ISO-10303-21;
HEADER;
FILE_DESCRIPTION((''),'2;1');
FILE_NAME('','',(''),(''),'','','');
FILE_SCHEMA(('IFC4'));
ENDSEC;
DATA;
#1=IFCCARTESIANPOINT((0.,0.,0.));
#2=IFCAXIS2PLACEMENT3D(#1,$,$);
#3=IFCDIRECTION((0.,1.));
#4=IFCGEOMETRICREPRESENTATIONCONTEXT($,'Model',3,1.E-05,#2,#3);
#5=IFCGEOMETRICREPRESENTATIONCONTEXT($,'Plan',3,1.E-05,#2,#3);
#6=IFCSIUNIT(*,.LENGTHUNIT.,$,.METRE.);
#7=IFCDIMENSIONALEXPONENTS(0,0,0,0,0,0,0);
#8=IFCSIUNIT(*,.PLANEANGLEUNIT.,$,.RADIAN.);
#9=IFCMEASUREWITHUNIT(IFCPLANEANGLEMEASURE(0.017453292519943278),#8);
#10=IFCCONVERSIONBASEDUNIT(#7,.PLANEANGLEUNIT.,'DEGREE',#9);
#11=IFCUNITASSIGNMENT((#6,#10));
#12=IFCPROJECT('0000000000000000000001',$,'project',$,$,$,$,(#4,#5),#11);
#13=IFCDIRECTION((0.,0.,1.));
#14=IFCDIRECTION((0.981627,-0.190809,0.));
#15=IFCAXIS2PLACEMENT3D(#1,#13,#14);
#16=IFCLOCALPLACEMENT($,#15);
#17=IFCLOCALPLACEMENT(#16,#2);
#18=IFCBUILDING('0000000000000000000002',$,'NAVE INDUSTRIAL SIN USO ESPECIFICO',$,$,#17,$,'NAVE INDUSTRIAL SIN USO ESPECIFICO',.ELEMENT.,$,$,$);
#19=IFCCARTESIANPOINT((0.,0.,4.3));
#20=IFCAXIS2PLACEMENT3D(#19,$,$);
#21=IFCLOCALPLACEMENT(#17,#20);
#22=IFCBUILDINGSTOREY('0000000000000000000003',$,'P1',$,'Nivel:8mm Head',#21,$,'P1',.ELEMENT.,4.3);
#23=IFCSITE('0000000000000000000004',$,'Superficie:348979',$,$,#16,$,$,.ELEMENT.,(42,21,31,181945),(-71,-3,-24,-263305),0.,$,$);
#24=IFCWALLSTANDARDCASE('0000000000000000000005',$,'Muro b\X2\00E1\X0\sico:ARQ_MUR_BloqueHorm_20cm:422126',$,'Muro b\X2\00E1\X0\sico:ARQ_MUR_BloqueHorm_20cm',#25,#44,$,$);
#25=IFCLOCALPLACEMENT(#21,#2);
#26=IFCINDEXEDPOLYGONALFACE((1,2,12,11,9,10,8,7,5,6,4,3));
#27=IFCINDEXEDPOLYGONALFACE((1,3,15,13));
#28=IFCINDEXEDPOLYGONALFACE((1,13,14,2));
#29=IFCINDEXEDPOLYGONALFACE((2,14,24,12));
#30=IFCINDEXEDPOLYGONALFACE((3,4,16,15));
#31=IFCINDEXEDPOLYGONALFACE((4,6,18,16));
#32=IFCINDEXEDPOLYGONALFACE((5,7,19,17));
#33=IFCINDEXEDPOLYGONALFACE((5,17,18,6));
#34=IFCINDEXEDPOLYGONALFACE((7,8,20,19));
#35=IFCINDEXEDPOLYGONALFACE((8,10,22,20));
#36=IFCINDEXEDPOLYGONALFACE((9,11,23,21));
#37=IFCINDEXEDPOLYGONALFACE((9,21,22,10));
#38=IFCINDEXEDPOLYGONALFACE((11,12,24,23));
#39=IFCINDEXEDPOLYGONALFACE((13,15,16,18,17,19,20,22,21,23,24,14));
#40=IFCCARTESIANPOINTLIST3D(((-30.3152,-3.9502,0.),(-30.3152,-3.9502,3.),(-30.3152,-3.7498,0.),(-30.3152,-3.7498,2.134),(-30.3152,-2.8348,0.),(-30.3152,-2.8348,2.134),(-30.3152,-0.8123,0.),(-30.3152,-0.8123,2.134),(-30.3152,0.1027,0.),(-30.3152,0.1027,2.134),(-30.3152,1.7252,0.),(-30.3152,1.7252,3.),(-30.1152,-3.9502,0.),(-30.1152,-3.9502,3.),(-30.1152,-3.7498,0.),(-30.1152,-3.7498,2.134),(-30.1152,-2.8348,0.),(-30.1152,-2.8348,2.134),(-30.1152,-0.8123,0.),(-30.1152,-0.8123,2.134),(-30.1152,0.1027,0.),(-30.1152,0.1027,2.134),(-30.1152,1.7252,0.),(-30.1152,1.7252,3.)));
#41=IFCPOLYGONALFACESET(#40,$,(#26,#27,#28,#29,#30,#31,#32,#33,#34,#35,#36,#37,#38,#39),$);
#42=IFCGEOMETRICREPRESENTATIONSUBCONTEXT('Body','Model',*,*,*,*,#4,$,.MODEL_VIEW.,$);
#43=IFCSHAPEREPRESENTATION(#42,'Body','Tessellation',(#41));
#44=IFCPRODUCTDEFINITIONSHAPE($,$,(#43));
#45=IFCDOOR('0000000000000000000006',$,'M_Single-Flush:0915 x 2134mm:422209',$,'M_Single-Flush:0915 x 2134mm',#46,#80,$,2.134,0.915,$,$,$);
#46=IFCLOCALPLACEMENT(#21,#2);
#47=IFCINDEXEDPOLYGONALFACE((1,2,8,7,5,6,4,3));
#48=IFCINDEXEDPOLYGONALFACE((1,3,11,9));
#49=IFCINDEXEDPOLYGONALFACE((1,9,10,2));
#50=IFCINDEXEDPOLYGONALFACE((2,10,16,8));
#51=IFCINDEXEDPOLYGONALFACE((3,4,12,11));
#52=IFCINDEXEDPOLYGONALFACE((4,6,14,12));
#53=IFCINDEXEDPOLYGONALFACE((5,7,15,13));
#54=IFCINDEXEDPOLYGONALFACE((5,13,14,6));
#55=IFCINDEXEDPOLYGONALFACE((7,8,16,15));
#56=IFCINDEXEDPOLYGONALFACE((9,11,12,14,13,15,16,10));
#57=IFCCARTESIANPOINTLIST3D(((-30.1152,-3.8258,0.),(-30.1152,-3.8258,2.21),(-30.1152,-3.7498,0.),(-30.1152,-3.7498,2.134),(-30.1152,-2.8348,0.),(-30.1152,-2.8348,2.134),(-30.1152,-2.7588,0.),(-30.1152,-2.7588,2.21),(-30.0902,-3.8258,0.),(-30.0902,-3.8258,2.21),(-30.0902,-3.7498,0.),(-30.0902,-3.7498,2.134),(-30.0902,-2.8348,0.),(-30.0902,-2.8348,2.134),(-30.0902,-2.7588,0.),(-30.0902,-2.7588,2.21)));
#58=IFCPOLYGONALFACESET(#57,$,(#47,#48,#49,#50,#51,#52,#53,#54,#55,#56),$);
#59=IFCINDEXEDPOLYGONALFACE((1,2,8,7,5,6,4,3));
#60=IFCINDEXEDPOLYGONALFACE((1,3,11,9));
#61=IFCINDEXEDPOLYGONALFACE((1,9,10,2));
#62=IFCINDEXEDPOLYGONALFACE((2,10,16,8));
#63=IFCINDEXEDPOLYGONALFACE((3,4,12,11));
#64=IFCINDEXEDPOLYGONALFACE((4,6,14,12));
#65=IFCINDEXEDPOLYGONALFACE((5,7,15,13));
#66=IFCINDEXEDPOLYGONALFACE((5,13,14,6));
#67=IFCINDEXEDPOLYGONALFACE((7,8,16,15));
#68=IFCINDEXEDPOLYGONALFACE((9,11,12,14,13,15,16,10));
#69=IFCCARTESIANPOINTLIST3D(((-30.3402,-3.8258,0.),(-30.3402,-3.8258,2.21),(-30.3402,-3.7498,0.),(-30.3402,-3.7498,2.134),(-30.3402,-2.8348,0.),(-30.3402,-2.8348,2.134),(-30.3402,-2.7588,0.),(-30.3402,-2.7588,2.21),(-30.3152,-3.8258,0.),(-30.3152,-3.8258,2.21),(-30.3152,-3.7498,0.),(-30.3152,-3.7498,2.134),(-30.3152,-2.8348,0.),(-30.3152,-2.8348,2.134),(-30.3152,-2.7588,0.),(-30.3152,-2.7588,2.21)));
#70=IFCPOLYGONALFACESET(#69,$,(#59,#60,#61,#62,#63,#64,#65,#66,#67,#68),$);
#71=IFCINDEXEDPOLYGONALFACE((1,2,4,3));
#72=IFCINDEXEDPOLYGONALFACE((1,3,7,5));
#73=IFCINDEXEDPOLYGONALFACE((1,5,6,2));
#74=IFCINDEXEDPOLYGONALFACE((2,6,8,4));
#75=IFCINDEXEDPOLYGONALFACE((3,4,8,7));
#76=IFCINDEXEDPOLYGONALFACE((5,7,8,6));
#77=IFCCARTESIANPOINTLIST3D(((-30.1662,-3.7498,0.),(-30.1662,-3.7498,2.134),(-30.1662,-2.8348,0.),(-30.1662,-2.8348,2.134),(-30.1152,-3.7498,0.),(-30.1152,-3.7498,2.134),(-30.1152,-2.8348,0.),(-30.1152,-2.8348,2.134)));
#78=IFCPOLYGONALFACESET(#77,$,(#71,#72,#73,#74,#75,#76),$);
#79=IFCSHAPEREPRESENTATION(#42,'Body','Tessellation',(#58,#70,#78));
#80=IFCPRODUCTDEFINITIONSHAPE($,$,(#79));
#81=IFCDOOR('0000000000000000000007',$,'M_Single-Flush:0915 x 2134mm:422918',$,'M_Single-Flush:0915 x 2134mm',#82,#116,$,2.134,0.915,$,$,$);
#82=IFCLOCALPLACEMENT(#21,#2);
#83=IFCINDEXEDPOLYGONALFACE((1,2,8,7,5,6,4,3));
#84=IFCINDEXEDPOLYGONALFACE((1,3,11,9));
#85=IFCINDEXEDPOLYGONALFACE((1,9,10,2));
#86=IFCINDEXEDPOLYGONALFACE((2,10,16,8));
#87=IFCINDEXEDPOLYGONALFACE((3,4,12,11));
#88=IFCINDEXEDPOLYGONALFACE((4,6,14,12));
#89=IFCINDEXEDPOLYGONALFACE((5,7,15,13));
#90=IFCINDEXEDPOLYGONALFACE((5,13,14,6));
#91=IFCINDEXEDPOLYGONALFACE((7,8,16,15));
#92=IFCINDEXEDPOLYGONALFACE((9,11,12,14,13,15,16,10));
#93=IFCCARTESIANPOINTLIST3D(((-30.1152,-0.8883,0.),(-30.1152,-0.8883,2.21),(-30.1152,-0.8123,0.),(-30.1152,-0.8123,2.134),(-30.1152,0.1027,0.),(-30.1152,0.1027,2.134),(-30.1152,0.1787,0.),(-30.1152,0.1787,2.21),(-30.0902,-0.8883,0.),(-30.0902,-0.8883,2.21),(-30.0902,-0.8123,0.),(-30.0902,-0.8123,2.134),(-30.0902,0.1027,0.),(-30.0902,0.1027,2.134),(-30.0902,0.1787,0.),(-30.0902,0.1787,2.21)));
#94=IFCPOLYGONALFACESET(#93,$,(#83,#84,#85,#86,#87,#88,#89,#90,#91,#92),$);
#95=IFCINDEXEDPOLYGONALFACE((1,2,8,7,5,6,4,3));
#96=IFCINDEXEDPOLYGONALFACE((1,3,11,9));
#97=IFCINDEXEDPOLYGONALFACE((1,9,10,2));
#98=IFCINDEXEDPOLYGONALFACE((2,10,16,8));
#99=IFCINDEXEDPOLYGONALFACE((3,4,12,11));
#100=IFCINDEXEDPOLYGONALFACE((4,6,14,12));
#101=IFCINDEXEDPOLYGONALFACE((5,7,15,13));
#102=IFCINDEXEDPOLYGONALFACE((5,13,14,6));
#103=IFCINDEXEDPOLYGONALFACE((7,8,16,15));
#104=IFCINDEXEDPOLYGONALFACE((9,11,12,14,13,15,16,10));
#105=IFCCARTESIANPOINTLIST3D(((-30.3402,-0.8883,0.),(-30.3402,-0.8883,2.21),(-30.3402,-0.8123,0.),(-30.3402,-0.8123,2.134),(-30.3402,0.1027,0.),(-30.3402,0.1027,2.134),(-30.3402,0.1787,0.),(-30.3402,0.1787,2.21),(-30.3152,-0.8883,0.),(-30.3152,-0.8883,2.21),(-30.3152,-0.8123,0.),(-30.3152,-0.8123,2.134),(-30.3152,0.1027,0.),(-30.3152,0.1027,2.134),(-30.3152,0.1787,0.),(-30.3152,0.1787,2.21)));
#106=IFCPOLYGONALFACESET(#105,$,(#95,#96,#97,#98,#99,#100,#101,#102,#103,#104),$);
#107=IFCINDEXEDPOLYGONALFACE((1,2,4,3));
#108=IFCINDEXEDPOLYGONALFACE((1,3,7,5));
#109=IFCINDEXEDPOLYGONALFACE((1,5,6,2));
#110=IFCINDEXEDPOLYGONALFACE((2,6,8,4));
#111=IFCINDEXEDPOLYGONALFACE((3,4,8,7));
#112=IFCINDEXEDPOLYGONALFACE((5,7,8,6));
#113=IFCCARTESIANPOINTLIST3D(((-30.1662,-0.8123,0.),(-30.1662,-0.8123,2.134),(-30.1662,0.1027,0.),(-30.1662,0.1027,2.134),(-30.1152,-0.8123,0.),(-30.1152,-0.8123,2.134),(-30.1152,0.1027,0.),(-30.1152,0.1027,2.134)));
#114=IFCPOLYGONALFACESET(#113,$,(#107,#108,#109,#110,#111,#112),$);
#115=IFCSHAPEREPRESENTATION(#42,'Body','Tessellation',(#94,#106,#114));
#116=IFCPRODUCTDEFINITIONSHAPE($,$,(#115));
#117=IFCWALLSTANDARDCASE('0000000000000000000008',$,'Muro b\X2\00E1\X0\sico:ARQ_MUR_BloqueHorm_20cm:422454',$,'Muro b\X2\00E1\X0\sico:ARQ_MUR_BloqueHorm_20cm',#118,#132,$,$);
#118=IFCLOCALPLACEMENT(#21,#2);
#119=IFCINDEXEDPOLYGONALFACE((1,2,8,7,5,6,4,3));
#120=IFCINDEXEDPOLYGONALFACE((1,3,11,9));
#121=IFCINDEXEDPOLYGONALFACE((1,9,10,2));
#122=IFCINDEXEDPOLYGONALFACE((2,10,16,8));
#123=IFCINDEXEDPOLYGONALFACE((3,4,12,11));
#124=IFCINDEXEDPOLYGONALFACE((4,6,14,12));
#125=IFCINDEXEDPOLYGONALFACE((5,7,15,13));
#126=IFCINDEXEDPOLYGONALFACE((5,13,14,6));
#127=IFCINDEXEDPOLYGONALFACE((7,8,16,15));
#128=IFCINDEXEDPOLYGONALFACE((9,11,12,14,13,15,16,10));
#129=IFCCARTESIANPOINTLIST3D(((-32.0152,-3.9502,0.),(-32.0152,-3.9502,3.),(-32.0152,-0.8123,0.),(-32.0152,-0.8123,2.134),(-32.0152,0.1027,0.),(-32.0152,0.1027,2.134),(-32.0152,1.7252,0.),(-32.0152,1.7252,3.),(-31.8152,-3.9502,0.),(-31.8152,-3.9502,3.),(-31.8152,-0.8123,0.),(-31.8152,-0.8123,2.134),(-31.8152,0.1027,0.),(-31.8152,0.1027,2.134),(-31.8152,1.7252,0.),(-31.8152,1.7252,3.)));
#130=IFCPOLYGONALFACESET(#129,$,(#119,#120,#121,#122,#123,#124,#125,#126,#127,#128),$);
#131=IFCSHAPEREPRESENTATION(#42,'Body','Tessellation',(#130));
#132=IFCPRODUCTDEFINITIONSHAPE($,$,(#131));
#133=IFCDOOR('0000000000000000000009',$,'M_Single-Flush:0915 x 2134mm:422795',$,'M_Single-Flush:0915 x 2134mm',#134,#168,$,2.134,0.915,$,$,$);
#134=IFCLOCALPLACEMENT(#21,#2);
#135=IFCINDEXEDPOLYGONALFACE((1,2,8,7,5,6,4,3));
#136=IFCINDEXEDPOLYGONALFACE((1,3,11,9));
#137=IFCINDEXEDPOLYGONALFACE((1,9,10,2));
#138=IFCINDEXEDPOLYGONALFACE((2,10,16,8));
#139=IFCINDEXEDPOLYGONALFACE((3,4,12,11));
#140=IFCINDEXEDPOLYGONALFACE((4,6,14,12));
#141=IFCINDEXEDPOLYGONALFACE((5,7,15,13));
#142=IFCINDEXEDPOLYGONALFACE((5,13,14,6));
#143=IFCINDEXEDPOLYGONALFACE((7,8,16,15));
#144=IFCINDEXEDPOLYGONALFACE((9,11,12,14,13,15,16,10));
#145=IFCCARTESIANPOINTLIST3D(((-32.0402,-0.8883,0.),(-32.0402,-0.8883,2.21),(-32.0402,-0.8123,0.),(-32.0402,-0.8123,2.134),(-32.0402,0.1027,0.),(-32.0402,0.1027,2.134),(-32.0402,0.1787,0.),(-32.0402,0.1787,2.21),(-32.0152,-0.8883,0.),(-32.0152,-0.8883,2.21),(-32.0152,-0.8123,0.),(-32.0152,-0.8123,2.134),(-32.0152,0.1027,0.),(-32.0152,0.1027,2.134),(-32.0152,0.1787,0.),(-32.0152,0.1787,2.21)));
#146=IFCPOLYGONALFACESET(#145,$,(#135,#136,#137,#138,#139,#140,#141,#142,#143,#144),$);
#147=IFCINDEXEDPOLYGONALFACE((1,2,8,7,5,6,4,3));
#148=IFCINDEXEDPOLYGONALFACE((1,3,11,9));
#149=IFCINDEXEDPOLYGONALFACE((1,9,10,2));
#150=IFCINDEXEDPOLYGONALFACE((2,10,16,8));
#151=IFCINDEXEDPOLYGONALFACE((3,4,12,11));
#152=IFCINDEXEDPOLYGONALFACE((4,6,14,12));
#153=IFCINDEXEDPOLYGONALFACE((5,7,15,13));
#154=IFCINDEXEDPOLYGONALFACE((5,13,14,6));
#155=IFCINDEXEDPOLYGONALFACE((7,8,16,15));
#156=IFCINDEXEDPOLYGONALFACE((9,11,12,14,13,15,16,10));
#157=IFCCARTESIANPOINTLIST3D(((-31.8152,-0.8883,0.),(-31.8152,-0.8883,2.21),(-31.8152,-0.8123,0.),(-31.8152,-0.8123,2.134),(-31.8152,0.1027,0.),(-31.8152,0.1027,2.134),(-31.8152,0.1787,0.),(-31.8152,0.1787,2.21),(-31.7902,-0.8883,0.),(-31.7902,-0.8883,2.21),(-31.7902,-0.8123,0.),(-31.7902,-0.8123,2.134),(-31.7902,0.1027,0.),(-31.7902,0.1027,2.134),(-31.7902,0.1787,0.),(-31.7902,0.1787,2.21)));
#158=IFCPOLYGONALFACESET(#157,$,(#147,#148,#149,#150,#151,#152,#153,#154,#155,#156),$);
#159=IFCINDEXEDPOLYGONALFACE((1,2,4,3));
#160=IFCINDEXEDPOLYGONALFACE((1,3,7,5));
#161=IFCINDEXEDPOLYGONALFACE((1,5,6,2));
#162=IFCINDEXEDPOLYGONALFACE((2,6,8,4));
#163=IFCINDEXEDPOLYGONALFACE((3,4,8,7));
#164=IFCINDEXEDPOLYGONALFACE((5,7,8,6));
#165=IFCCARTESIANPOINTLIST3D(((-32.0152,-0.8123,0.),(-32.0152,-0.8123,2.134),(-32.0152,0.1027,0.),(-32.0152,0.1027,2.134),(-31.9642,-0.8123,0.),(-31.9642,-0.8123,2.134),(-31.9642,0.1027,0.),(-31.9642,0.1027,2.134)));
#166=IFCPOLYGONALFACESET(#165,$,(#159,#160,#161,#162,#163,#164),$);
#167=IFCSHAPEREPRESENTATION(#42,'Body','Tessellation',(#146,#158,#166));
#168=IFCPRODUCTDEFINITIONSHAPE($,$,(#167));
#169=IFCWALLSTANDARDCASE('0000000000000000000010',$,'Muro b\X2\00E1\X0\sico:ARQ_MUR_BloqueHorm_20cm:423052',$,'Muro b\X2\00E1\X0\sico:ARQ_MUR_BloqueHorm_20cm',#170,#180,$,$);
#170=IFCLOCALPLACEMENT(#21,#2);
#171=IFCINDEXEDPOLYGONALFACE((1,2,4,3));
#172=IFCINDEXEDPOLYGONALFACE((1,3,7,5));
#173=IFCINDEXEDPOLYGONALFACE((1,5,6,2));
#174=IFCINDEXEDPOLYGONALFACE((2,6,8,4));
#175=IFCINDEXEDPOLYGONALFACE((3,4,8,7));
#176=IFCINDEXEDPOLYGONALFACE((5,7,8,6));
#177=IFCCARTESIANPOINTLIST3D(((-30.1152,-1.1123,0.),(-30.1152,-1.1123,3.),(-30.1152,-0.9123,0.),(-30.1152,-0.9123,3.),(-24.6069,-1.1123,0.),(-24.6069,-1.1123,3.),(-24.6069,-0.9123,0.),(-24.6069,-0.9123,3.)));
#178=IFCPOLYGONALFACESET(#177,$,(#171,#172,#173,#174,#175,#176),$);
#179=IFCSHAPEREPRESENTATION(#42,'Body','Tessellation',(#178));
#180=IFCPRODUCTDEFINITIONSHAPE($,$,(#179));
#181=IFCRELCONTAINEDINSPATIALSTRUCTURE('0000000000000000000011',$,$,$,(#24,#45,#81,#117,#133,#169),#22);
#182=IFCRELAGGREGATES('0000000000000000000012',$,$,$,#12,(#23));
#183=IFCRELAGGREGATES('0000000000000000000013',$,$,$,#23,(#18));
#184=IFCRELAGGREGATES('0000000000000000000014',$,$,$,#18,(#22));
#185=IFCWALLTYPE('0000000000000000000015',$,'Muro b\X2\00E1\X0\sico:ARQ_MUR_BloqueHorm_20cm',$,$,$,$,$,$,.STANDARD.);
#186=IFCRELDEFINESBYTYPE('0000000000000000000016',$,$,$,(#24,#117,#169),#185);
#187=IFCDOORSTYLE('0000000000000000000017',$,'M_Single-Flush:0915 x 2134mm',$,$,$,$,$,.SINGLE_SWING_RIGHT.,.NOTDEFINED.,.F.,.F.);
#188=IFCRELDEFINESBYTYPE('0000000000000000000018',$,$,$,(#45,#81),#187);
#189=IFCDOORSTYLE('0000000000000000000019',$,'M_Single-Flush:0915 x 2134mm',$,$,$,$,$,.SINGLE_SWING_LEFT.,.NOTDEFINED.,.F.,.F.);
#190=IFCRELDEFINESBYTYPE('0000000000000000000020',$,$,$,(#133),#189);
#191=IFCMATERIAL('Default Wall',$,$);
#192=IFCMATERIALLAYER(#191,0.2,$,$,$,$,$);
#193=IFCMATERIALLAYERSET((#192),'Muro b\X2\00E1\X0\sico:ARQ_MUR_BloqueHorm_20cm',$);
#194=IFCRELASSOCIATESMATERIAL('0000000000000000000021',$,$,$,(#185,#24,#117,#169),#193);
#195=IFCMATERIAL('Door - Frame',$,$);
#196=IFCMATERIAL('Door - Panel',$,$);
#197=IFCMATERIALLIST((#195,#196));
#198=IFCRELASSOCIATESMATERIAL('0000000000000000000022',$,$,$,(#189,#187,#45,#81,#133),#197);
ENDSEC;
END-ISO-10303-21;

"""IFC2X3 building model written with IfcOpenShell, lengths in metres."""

from ifc_helpers import new_model, entity, si_unit, converted_unit, direction, frame, frame_2d, origin, place, context, subcontext, project, spatial, polyline, rectangle, outline, extrude, source, transform, mapped, material, material_list, layer, layer_set, layer_usage, type_object, type_shapes, element, fill, save


model = new_model("IFC2X3")

# Units and contexts
model_context = context("Model", 3, precision=1e-05, world=origin(), true_north=direction((0.0, 1.0)))
plan_context = context("Plan", 3, precision=1e-05, world=origin(), true_north=direction((0.0, 1.0)))
body_context = subcontext(model_context, "Body", "Model", "MODEL_VIEW")
ifc_project = project(units=[si_unit("LENGTHUNIT", "METRE"), converted_unit("PLANEANGLEUNIT", "DEGREE", entity("IfcPlaneAngleMeasure", 0.017453292519943278), si_unit("PLANEANGLEUNIT", "RADIAN"), dimensions=[0, 0, 0, 0, 0, 0, 0])], contexts=[model_context, plan_context])

# Site, building, storey
site_placement = place(None, frame((0.0, 0.0, 0.0), z_axis=(0.0, 0.0, 1.0), x_axis=(0.981627, -0.190809, 0.0)))
site = spatial("IfcSite", under=ifc_project, at=site_placement, Name="Superficie:348979", CompositionType="ELEMENT", RefLatitude=(42, 21, 31, 181945), RefLongitude=(-71, -3, -24, -263305), RefElevation=0.0)
building_placement = place(site_placement, origin())
building = spatial("IfcBuilding", under=site, at=building_placement, Name="NAVE INDUSTRIAL SIN USO ESPECIFICO", LongName="NAVE INDUSTRIAL SIN USO ESPECIFICO", CompositionType="ELEMENT")
storey_placement = place(building_placement, frame((0.0, 0.0, 4.3)))
storey = spatial("IfcBuildingStorey", under=building, at=storey_placement, Name="P1", ObjectType="Nivel:8mm Head", LongName="P1", CompositionType="ELEMENT", Elevation=4.3)

# Shared definitions
ifc_material_1 = material(Name="Default Wall")
ifc_layer_1 = layer(ifc_material_1, 0.2)
ifc_layer_set_1 = layer_set([ifc_layer_1], Name="Muro básico:ARQ_MUR_BloqueHorm_20cm")
wall_type_1 = type_object("IfcWallType", Name="Muro básico:ARQ_MUR_BloqueHorm_20cm", PredefinedType="STANDARD", material=ifc_layer_set_1)

# Shared definitions
ifc_material_2 = material(Name="Door - Frame")
ifc_material_3 = material(Name="Door - Panel")
ifc_material_list = material_list([ifc_material_2, ifc_material_3])
door_style_1 = type_object("IfcDoorStyle", Name="M_Single-Flush:0915 x 2134mm", ConstructionType="NOTDEFINED", OperationType="SINGLE_SWING_LEFT", ParameterTakesPrecedence=False, Sizeable=False, material=ifc_material_list)
shared_shape_1 = source(origin(), body_context, "Body", "SweptSolid", [
    extrude(outline(polyline([(-0.5335, -1.124), (0.5335, -1.124), (0.5335, 1.086), (0.4575, 1.086), (0.4575, -1.048), (-0.4575, -1.048), (-0.4575, 1.086), (-0.5335, 1.086), (-0.5335, -1.124)])), frame((0.4575, 0.225, 1.086), z_axis=(0.0, -1.0, 0.0), x_axis=(-1.0, 0.0, 0.0)), (0.0, 0.0, 1.0), 0.025),
    extrude(outline(polyline([(-1.124, -0.5335), (1.086, -0.5335), (1.086, -0.4575), (-1.048, -0.4575), (-1.048, 0.4575), (1.086, 0.4575), (1.086, 0.5335), (-1.124, 0.5335), (-1.124, -0.5335)])), frame((0.4575, 0.0, 1.086), z_axis=(0.0, -1.0, 0.0), x_axis=(0.0, 0.0, -1.0)), (0.0, 0.0, 1.0), 0.025),
    extrude(rectangle(XDim=0.915, YDim=0.051, at=frame_2d((0.0, 0.0), x_axis=(1.0, 0.0))), frame((0.4575, 0.1745, 0.0)), (0.0, 0.0, 1.0), 2.134),
])
type_shapes(door_style_1, [shared_shape_1])

# Wall, openings, doors
ifc_layer_usage_1 = layer_usage(ifc_layer_set_1, "AXIS2", "NEGATIVE", 0.1)
wall_1_placement = place(storey_placement, frame((-30.2152, -3.9502, 0.0), z_axis=(0.0, 0.0, 1.0), x_axis=(0.0, 1.0, 0.0)))
wall_1 = element("IfcWallStandardCase", 1, at=wall_1_placement, inside=storey, type_object=wall_type_1, material=ifc_layer_usage_1, Name="Muro básico:ARQ_MUR_BloqueHorm_20cm:422126", ObjectType="Muro básico:ARQ_MUR_BloqueHorm_20cm", context=body_context, shape_type="SweptSolid", body=[
    extrude(rectangle(XDim=5.6754, YDim=0.2, at=frame_2d((2.8377, 0.0), x_axis=(1.0, 0.0))), origin(), (0.0, 0.0, 1.0), 3.0),
])
opening_1_placement = place(wall_1_placement, frame((1.1154, 0.1, 0.0)))
opening_1 = element("IfcOpeningElement", 2, at=opening_1_placement, cuts=wall_1, ObjectType="Opening", context=body_context, shape_type="SweptSolid", body=[
    extrude(rectangle(XDim=0.915, YDim=2.134, at=frame_2d((1.067, 0.4575), x_axis=(0.0, 1.0))), frame((0.0, 0.0, 0.0), z_axis=(0.0, -1.0, 0.0), x_axis=(0.0, 0.0, 1.0)), (0.0, 0.0, 1.0), 0.2),
])
opening_2_placement = place(wall_1_placement, frame((4.0529, 0.1, 0.0)))
opening_2 = element("IfcOpeningElement", 3, at=opening_2_placement, cuts=wall_1, ObjectType="Opening", context=body_context, shape_type="SweptSolid", body=[
    extrude(rectangle(XDim=0.915, YDim=2.134, at=frame_2d((1.067, 0.4575), x_axis=(0.0, 1.0))), frame((0.0, 0.0, 0.0), z_axis=(0.0, -1.0, 0.0), x_axis=(0.0, 0.0, 1.0)), (0.0, 0.0, 1.0), 0.2),
])
door_style_2 = type_object("IfcDoorStyle", Name="M_Single-Flush:0915 x 2134mm", ConstructionType="NOTDEFINED", OperationType="SINGLE_SWING_RIGHT", ParameterTakesPrecedence=False, Sizeable=False, material=ifc_material_list)
shared_shape_2 = source(origin(), body_context, "Body", "SweptSolid", [
    extrude(outline(polyline([(-0.5335, -1.124), (0.5335, -1.124), (0.5335, 1.086), (0.4575, 1.086), (0.4575, -1.048), (-0.4575, -1.048), (-0.4575, 1.086), (-0.5335, 1.086), (-0.5335, -1.124)])), frame((0.4575, 0.2, 1.086), z_axis=(0.0, 1.0, 0.0), x_axis=(1.0, 0.0, 0.0)), (0.0, 0.0, 1.0), 0.025),
    extrude(outline(polyline([(-1.124, -0.5335), (1.086, -0.5335), (1.086, -0.4575), (-1.048, -0.4575), (-1.048, 0.4575), (1.086, 0.4575), (1.086, 0.5335), (-1.124, 0.5335), (-1.124, -0.5335)])), frame((0.4575, -0.025, 1.086), z_axis=(0.0, 1.0, 0.0), x_axis=(0.0, 0.0, -1.0)), (0.0, 0.0, 1.0), 0.025),
    extrude(rectangle(XDim=0.051, YDim=0.915, at=frame_2d((0.0, 0.0), x_axis=(1.0, 0.0))), frame((0.4575, 0.1745, 0.0), z_axis=(0.0, 0.0, 1.0), x_axis=(0.0, 1.0, 0.0)), (0.0, 0.0, 1.0), 2.134),
])
type_shapes(door_style_2, [shared_shape_2])
door_1_placement = place(opening_1_placement, frame((0.0, 0.0, 0.0), z_axis=(0.0, 0.0, 1.0), x_axis=(-1.0, 0.0, 0.0)))
door_1 = element("IfcDoor", 4, at=door_1_placement, inside=storey, type_object=door_style_2, material=ifc_material_list, Name="M_Single-Flush:0915 x 2134mm:422209", ObjectType="M_Single-Flush:0915 x 2134mm", OverallHeight=2.134, OverallWidth=0.915, context=body_context, shape_type="MappedRepresentation", body=[
    mapped(shared_shape_2, transform((0.0, 0.0, 0.0), scale=1.0)),
])
fill(opening_1, door_1)
door_2_placement = place(opening_2_placement, frame((0.0, 0.0, 0.0), z_axis=(0.0, 0.0, 1.0), x_axis=(-1.0, 0.0, 0.0)))
door_2 = element("IfcDoor", 5, at=door_2_placement, inside=storey, type_object=door_style_2, material=ifc_material_list, Name="M_Single-Flush:0915 x 2134mm:422918", ObjectType="M_Single-Flush:0915 x 2134mm", OverallHeight=2.134, OverallWidth=0.915, context=body_context, shape_type="MappedRepresentation", body=[
    mapped(shared_shape_2, transform((0.0, 0.0, 0.0), scale=1.0)),
])
fill(opening_2, door_2)

# Wall, opening, door
ifc_layer_usage_2 = layer_usage(ifc_layer_set_1, "AXIS2", "NEGATIVE", 0.1)
wall_2_placement = place(storey_placement, frame((-31.9152, -3.9502, 0.0), z_axis=(0.0, 0.0, 1.0), x_axis=(0.0, 1.0, 0.0)))
wall_2 = element("IfcWallStandardCase", 6, at=wall_2_placement, inside=storey, type_object=wall_type_1, material=ifc_layer_usage_2, Name="Muro básico:ARQ_MUR_BloqueHorm_20cm:422454", ObjectType="Muro básico:ARQ_MUR_BloqueHorm_20cm", context=body_context, shape_type="SweptSolid", body=[
    extrude(rectangle(XDim=5.6754, YDim=0.2, at=frame_2d((2.8377, 0.0), x_axis=(1.0, 0.0))), origin(), (0.0, 0.0, 1.0), 3.0),
])
opening_3_placement = place(wall_2_placement, frame((3.1379, -0.1, 0.0)))
opening_3 = element("IfcOpeningElement", 7, at=opening_3_placement, cuts=wall_2, ObjectType="Opening", context=body_context, shape_type="SweptSolid", body=[
    extrude(rectangle(XDim=0.915, YDim=2.134, at=frame_2d((1.067, 0.4575), x_axis=(0.0, -1.0))), frame((0.0, 0.0, 0.0), z_axis=(0.0, 1.0, 0.0), x_axis=(0.0, 0.0, 1.0)), (0.0, 0.0, 1.0), 0.2),
])
door_3_placement = place(opening_3_placement, origin())
door_3 = element("IfcDoor", 8, at=door_3_placement, inside=storey, type_object=door_style_1, material=ifc_material_list, Name="M_Single-Flush:0915 x 2134mm:422795", ObjectType="M_Single-Flush:0915 x 2134mm", OverallHeight=2.134, OverallWidth=0.915, context=body_context, shape_type="MappedRepresentation", body=[
    mapped(shared_shape_1, transform((0.0, 0.0, 0.0), scale=1.0)),
])
fill(opening_3, door_3)

# Wall
ifc_layer_usage_3 = layer_usage(ifc_layer_set_1, "AXIS2", "NEGATIVE", 0.1)
wall_3_placement = place(storey_placement, frame((-30.1152, -1.0123, 0.0)))
element("IfcWallStandardCase", 9, at=wall_3_placement, inside=storey, type_object=wall_type_1, material=ifc_layer_usage_3, Name="Muro básico:ARQ_MUR_BloqueHorm_20cm:423052", ObjectType="Muro básico:ARQ_MUR_BloqueHorm_20cm", context=body_context, shape_type="SweptSolid", body=[
    extrude(rectangle(XDim=5.5083, YDim=0.2, at=frame_2d((2.7542, 0.0), x_axis=(-1.0, 0.0))), origin(), (0.0, 0.0, 1.0), 3.0),
])

save(model, "model.ifc")
